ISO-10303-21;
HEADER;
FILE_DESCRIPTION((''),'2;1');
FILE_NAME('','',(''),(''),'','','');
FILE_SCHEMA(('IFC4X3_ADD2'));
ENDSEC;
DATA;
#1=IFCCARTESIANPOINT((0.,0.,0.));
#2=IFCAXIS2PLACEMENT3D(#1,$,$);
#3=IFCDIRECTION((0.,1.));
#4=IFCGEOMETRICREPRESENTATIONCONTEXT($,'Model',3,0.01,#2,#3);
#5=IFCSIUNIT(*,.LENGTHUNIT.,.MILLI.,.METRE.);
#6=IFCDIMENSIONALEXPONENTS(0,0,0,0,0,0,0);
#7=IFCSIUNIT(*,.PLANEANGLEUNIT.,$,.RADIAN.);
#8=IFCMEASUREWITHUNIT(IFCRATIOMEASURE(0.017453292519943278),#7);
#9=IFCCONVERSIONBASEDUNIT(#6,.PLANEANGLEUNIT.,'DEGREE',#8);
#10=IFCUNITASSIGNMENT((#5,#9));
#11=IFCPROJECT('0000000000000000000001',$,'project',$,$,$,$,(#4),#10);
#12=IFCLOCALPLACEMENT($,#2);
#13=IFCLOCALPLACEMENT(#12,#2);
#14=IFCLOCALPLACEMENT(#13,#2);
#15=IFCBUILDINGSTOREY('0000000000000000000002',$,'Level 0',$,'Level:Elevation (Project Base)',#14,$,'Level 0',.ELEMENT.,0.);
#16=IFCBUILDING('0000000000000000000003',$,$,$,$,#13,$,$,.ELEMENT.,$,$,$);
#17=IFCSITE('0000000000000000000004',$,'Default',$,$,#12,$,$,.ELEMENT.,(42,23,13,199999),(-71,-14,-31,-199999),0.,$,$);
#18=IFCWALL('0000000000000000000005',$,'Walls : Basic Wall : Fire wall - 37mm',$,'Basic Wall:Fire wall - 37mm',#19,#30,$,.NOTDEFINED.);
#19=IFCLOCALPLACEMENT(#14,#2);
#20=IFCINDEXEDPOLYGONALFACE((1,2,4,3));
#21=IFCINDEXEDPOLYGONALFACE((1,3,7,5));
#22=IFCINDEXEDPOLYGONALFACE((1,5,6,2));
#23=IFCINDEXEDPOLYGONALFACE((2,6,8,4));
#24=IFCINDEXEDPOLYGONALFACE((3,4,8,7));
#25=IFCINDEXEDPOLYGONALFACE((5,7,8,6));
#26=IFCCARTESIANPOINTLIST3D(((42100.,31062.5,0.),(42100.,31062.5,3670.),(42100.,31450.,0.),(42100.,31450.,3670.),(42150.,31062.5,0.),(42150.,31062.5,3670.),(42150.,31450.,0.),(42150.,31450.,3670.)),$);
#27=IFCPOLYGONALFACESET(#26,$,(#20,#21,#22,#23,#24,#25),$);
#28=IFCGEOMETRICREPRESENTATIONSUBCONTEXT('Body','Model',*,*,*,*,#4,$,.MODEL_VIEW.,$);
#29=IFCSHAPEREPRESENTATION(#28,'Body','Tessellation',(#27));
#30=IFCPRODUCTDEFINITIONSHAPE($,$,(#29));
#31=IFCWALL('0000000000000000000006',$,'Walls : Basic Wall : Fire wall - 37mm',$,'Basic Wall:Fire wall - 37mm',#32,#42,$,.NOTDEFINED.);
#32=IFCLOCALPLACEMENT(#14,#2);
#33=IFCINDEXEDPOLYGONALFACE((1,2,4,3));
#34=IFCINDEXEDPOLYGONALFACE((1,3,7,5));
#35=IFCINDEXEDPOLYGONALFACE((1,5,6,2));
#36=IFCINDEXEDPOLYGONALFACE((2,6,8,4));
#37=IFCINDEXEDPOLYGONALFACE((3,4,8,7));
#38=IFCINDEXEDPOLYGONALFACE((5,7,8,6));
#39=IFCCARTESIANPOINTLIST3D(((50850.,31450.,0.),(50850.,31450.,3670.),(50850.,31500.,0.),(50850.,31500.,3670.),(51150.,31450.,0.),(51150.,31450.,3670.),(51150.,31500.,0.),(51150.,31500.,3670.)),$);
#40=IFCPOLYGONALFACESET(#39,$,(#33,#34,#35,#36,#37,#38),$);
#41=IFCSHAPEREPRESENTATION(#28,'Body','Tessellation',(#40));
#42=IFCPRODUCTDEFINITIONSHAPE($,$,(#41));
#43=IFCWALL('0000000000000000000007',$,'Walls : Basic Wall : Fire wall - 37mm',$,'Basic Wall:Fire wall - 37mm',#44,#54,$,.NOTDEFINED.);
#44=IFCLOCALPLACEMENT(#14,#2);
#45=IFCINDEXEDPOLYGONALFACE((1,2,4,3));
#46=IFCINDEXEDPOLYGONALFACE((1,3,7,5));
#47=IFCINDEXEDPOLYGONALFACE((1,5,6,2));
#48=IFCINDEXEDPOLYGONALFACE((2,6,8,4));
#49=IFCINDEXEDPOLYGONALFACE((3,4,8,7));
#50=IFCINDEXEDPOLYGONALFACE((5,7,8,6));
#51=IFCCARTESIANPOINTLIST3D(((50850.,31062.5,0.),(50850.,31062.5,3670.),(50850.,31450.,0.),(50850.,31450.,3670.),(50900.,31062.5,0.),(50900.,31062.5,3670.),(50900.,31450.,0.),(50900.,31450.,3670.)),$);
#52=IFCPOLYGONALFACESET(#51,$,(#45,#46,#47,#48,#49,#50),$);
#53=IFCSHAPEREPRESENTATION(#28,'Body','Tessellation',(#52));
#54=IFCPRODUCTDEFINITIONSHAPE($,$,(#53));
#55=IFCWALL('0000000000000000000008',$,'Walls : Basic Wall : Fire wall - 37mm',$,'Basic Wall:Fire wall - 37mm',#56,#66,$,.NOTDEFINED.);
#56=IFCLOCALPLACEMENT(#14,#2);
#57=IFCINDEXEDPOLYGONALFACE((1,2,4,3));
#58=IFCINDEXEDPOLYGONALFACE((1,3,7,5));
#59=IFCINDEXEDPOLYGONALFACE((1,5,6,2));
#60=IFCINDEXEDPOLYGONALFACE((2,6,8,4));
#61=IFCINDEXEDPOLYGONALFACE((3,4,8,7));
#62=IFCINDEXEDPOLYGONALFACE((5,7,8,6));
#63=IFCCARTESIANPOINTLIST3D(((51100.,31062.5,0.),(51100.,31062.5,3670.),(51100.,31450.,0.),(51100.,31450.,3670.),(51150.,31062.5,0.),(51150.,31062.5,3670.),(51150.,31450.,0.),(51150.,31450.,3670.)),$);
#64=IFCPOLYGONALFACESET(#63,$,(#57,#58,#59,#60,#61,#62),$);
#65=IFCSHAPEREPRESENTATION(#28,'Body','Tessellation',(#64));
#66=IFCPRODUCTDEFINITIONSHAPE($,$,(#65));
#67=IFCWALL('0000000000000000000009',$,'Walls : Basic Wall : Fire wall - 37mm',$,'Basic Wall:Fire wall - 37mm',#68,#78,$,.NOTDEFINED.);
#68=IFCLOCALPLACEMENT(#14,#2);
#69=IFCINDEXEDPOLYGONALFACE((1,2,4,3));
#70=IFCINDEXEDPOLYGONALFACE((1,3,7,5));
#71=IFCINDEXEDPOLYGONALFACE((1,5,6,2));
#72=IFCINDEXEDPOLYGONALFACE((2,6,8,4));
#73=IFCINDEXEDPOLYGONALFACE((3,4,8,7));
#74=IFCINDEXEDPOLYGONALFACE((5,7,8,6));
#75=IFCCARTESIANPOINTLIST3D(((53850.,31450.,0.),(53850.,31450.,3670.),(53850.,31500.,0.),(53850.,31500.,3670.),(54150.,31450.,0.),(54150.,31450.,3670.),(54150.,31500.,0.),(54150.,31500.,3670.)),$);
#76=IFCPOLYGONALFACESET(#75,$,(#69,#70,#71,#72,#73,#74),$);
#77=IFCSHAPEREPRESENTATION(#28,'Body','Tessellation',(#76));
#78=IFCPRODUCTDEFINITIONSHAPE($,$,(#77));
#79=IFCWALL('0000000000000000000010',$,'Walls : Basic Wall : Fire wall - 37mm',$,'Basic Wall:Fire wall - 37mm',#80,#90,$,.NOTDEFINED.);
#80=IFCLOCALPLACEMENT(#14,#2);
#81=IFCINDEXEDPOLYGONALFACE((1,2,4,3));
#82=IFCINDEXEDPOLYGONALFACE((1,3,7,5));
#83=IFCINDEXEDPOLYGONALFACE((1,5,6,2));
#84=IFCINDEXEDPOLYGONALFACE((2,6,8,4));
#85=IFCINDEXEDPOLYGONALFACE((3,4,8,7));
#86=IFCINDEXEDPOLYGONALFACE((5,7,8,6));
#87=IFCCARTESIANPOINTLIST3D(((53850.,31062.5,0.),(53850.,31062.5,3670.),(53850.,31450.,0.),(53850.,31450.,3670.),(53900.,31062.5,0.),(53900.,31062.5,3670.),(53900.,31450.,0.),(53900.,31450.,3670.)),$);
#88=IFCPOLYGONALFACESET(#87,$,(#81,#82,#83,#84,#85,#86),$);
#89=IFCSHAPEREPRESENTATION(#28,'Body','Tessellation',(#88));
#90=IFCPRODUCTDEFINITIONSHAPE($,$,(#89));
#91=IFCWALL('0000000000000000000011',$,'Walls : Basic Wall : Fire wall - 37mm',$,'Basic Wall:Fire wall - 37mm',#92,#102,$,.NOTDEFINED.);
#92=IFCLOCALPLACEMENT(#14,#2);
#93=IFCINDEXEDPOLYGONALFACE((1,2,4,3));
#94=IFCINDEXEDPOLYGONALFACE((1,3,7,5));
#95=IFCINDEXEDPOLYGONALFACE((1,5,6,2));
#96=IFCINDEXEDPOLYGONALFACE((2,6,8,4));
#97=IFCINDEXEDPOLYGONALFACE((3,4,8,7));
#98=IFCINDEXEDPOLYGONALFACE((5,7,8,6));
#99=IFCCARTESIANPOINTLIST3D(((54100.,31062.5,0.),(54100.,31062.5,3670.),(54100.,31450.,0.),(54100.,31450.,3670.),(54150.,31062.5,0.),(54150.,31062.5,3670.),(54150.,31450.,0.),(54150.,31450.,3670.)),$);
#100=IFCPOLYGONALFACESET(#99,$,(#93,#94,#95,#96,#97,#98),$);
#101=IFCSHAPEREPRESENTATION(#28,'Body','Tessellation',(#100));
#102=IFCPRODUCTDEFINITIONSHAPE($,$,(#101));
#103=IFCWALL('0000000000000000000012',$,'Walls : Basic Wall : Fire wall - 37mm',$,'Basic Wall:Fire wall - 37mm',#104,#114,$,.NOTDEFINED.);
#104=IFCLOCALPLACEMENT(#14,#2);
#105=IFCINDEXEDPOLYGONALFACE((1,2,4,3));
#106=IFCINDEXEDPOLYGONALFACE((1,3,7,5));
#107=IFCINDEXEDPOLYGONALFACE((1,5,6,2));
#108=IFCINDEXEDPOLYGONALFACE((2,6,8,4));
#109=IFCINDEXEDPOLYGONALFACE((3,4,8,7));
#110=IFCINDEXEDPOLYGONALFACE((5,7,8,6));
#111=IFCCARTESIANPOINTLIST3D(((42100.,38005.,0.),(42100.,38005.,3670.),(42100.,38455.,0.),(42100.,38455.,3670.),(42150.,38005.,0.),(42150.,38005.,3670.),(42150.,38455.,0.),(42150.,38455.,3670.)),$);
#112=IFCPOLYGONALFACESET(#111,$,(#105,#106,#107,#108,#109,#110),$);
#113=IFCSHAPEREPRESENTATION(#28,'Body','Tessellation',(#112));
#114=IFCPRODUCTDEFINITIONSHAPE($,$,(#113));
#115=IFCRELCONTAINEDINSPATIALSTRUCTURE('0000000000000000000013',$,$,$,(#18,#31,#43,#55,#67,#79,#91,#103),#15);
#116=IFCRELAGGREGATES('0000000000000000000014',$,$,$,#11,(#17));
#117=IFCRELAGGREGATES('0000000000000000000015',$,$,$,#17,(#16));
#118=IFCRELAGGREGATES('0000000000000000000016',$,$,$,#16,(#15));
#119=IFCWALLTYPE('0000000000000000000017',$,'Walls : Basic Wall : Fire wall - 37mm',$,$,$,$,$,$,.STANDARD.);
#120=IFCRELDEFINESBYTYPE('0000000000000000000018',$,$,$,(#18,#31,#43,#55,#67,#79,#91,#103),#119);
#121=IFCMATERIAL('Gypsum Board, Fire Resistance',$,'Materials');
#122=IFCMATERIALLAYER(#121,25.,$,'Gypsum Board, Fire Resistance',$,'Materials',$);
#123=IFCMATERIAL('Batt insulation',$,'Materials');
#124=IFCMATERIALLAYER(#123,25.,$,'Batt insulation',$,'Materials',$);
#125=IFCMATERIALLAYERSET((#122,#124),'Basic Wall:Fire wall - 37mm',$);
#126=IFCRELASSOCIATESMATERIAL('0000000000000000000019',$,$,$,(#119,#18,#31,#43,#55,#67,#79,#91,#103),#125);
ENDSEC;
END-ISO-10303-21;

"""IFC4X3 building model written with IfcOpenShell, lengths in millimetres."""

from ifc_helpers import new_model, entity, si_unit, converted_unit, direction, frame, frame_2d, origin, place, context, subcontext, project, spatial, rectangle, extrude, material, layer, layer_set, type_object, element, save


model = new_model("IFC4X3")

# Units and contexts
model_context = context("Model", 3, precision=0.01, world=origin(), true_north=direction((0.0, 1.0)))
body_context = subcontext(model_context, "Body", "Model", "MODEL_VIEW")
ifc_project = project(units=[si_unit("LENGTHUNIT", "METRE", prefix="MILLI"), converted_unit("PLANEANGLEUNIT", "DEGREE", entity("IfcRatioMeasure", 0.017453292519943278), si_unit("PLANEANGLEUNIT", "RADIAN"), dimensions=[0, 0, 0, 0, 0, 0, 0])], contexts=[model_context])

# Site, building, storey
site_placement = place(None, origin())
site = spatial("IfcSite", under=ifc_project, at=site_placement, Name="Default", CompositionType="ELEMENT", RefLatitude=(42, 23, 13, 199999), RefLongitude=(-71, -14, -31, -199999), RefElevation=0.0)
building_placement = place(site_placement, origin())
building = spatial("IfcBuilding", under=site, at=building_placement, CompositionType="ELEMENT")
storey_placement = place(building_placement, origin())
storey = spatial("IfcBuildingStorey", under=building, at=storey_placement, Name="Level 0", ObjectType="Level:Elevation (Project Base)", LongName="Level 0", CompositionType="ELEMENT", Elevation=0.0)

# Walls
ifc_material_1 = material(Name="Gypsum Board, Fire Resistance", Category="Materials")
ifc_layer_1 = layer(ifc_material_1, 25.0, Name="Gypsum Board, Fire Resistance", Category="Materials")
ifc_material_2 = material(Name="Batt insulation", Category="Materials")
ifc_layer_2 = layer(ifc_material_2, 25.0, Name="Batt insulation", Category="Materials")
ifc_layer_set = layer_set([ifc_layer_1, ifc_layer_2], Name="Basic Wall:Fire wall - 37mm")
wall_type = type_object("IfcWallType", Name="Walls : Basic Wall : Fire wall - 37mm", PredefinedType="STANDARD", material=ifc_layer_set)
wall_1_placement = place(storey_placement, frame((42125.0, 31450.0, 0.0), z_axis=(0.0, 0.0, 1.0), x_axis=(0.0, -1.0, 0.0)))
element("IfcWall", 1, at=wall_1_placement, inside=storey, type_object=wall_type, material=ifc_layer_set, Name="Walls : Basic Wall : Fire wall - 37mm", ObjectType="Basic Wall:Fire wall - 37mm", PredefinedType="NOTDEFINED", context=body_context, shape_type="SweptSolid", body=[
    extrude(rectangle(XDim=387.5, YDim=50.0, at=frame_2d((193.7, 0.0), x_axis=(-1.0, 0.0))), origin(), (0.0, 0.0, 1.0), 3670.0),
])
wall_2_placement = place(storey_placement, frame((50850.0, 31475.0, 0.0)))
element("IfcWall", 2, at=wall_2_placement, inside=storey, type_object=wall_type, material=ifc_layer_set, Name="Walls : Basic Wall : Fire wall - 37mm", ObjectType="Basic Wall:Fire wall - 37mm", PredefinedType="NOTDEFINED", context=body_context, shape_type="SweptSolid", body=[
    extrude(rectangle(XDim=300.0, YDim=50.0, at=frame_2d((150.0, 0.0), x_axis=(-1.0, 0.0))), origin(), (0.0, 0.0, 1.0), 3670.0),
])
wall_3_placement = place(storey_placement, frame((50875.0, 31450.0, 0.0), z_axis=(0.0, 0.0, 1.0), x_axis=(0.0, -1.0, 0.0)))
element("IfcWall", 3, at=wall_3_placement, inside=storey, type_object=wall_type, material=ifc_layer_set, Name="Walls : Basic Wall : Fire wall - 37mm", ObjectType="Basic Wall:Fire wall - 37mm", PredefinedType="NOTDEFINED", context=body_context, shape_type="SweptSolid", body=[
    extrude(rectangle(XDim=387.5, YDim=50.0, at=frame_2d((193.8, 0.0), x_axis=(-1.0, 0.0))), origin(), (0.0, 0.0, 1.0), 3670.0),
])
wall_4_placement = place(storey_placement, frame((51125.0, 31450.0, 0.0), z_axis=(0.0, 0.0, 1.0), x_axis=(0.0, -1.0, 0.0)))
element("IfcWall", 4, at=wall_4_placement, inside=storey, type_object=wall_type, material=ifc_layer_set, Name="Walls : Basic Wall : Fire wall - 37mm", ObjectType="Basic Wall:Fire wall - 37mm", PredefinedType="NOTDEFINED", context=body_context, shape_type="SweptSolid", body=[
    extrude(rectangle(XDim=387.5, YDim=50.0, at=frame_2d((193.8, 0.0), x_axis=(-1.0, 0.0))), origin(), (0.0, 0.0, 1.0), 3670.0),
])
wall_5_placement = place(storey_placement, frame((53850.0, 31475.0, 0.0)))
element("IfcWall", 5, at=wall_5_placement, inside=storey, type_object=wall_type, material=ifc_layer_set, Name="Walls : Basic Wall : Fire wall - 37mm", ObjectType="Basic Wall:Fire wall - 37mm", PredefinedType="NOTDEFINED", context=body_context, shape_type="SweptSolid", body=[
    extrude(rectangle(XDim=300.0, YDim=50.0, at=frame_2d((150.0, 0.0), x_axis=(-1.0, 0.0))), origin(), (0.0, 0.0, 1.0), 3670.0),
])
wall_6_placement = place(storey_placement, frame((53875.0, 31450.0, 0.0), z_axis=(0.0, 0.0, 1.0), x_axis=(0.0, -1.0, 0.0)))
element("IfcWall", 6, at=wall_6_placement, inside=storey, type_object=wall_type, material=ifc_layer_set, Name="Walls : Basic Wall : Fire wall - 37mm", ObjectType="Basic Wall:Fire wall - 37mm", PredefinedType="NOTDEFINED", context=body_context, shape_type="SweptSolid", body=[
    extrude(rectangle(XDim=387.5, YDim=50.0, at=frame_2d((193.8, 0.0), x_axis=(-1.0, 0.0))), origin(), (0.0, 0.0, 1.0), 3670.0),
])
wall_7_placement = place(storey_placement, frame((54125.0, 31450.0, 0.0), z_axis=(0.0, 0.0, 1.0), x_axis=(0.0, -1.0, 0.0)))
element("IfcWall", 7, at=wall_7_placement, inside=storey, type_object=wall_type, material=ifc_layer_set, Name="Walls : Basic Wall : Fire wall - 37mm", ObjectType="Basic Wall:Fire wall - 37mm", PredefinedType="NOTDEFINED", context=body_context, shape_type="SweptSolid", body=[
    extrude(rectangle(XDim=387.5, YDim=50.0, at=frame_2d((193.8, 0.0), x_axis=(-1.0, 0.0))), origin(), (0.0, 0.0, 1.0), 3670.0),
])
wall_8_placement = place(storey_placement, frame((42125.0, 38455.0, 0.0), z_axis=(0.0, 0.0, 1.0), x_axis=(0.0, -1.0, 0.0)))
element("IfcWall", 8, at=wall_8_placement, inside=storey, type_object=wall_type, material=ifc_layer_set, Name="Walls : Basic Wall : Fire wall - 37mm", ObjectType="Basic Wall:Fire wall - 37mm", PredefinedType="NOTDEFINED", context=body_context, shape_type="SweptSolid", body=[
    extrude(rectangle(XDim=450.0, YDim=50.0, at=frame_2d((225.0, 0.0), x_axis=(-1.0, 0.0))), origin(), (0.0, 0.0, 1.0), 3670.0),
])

save(model, "model.ifc")
